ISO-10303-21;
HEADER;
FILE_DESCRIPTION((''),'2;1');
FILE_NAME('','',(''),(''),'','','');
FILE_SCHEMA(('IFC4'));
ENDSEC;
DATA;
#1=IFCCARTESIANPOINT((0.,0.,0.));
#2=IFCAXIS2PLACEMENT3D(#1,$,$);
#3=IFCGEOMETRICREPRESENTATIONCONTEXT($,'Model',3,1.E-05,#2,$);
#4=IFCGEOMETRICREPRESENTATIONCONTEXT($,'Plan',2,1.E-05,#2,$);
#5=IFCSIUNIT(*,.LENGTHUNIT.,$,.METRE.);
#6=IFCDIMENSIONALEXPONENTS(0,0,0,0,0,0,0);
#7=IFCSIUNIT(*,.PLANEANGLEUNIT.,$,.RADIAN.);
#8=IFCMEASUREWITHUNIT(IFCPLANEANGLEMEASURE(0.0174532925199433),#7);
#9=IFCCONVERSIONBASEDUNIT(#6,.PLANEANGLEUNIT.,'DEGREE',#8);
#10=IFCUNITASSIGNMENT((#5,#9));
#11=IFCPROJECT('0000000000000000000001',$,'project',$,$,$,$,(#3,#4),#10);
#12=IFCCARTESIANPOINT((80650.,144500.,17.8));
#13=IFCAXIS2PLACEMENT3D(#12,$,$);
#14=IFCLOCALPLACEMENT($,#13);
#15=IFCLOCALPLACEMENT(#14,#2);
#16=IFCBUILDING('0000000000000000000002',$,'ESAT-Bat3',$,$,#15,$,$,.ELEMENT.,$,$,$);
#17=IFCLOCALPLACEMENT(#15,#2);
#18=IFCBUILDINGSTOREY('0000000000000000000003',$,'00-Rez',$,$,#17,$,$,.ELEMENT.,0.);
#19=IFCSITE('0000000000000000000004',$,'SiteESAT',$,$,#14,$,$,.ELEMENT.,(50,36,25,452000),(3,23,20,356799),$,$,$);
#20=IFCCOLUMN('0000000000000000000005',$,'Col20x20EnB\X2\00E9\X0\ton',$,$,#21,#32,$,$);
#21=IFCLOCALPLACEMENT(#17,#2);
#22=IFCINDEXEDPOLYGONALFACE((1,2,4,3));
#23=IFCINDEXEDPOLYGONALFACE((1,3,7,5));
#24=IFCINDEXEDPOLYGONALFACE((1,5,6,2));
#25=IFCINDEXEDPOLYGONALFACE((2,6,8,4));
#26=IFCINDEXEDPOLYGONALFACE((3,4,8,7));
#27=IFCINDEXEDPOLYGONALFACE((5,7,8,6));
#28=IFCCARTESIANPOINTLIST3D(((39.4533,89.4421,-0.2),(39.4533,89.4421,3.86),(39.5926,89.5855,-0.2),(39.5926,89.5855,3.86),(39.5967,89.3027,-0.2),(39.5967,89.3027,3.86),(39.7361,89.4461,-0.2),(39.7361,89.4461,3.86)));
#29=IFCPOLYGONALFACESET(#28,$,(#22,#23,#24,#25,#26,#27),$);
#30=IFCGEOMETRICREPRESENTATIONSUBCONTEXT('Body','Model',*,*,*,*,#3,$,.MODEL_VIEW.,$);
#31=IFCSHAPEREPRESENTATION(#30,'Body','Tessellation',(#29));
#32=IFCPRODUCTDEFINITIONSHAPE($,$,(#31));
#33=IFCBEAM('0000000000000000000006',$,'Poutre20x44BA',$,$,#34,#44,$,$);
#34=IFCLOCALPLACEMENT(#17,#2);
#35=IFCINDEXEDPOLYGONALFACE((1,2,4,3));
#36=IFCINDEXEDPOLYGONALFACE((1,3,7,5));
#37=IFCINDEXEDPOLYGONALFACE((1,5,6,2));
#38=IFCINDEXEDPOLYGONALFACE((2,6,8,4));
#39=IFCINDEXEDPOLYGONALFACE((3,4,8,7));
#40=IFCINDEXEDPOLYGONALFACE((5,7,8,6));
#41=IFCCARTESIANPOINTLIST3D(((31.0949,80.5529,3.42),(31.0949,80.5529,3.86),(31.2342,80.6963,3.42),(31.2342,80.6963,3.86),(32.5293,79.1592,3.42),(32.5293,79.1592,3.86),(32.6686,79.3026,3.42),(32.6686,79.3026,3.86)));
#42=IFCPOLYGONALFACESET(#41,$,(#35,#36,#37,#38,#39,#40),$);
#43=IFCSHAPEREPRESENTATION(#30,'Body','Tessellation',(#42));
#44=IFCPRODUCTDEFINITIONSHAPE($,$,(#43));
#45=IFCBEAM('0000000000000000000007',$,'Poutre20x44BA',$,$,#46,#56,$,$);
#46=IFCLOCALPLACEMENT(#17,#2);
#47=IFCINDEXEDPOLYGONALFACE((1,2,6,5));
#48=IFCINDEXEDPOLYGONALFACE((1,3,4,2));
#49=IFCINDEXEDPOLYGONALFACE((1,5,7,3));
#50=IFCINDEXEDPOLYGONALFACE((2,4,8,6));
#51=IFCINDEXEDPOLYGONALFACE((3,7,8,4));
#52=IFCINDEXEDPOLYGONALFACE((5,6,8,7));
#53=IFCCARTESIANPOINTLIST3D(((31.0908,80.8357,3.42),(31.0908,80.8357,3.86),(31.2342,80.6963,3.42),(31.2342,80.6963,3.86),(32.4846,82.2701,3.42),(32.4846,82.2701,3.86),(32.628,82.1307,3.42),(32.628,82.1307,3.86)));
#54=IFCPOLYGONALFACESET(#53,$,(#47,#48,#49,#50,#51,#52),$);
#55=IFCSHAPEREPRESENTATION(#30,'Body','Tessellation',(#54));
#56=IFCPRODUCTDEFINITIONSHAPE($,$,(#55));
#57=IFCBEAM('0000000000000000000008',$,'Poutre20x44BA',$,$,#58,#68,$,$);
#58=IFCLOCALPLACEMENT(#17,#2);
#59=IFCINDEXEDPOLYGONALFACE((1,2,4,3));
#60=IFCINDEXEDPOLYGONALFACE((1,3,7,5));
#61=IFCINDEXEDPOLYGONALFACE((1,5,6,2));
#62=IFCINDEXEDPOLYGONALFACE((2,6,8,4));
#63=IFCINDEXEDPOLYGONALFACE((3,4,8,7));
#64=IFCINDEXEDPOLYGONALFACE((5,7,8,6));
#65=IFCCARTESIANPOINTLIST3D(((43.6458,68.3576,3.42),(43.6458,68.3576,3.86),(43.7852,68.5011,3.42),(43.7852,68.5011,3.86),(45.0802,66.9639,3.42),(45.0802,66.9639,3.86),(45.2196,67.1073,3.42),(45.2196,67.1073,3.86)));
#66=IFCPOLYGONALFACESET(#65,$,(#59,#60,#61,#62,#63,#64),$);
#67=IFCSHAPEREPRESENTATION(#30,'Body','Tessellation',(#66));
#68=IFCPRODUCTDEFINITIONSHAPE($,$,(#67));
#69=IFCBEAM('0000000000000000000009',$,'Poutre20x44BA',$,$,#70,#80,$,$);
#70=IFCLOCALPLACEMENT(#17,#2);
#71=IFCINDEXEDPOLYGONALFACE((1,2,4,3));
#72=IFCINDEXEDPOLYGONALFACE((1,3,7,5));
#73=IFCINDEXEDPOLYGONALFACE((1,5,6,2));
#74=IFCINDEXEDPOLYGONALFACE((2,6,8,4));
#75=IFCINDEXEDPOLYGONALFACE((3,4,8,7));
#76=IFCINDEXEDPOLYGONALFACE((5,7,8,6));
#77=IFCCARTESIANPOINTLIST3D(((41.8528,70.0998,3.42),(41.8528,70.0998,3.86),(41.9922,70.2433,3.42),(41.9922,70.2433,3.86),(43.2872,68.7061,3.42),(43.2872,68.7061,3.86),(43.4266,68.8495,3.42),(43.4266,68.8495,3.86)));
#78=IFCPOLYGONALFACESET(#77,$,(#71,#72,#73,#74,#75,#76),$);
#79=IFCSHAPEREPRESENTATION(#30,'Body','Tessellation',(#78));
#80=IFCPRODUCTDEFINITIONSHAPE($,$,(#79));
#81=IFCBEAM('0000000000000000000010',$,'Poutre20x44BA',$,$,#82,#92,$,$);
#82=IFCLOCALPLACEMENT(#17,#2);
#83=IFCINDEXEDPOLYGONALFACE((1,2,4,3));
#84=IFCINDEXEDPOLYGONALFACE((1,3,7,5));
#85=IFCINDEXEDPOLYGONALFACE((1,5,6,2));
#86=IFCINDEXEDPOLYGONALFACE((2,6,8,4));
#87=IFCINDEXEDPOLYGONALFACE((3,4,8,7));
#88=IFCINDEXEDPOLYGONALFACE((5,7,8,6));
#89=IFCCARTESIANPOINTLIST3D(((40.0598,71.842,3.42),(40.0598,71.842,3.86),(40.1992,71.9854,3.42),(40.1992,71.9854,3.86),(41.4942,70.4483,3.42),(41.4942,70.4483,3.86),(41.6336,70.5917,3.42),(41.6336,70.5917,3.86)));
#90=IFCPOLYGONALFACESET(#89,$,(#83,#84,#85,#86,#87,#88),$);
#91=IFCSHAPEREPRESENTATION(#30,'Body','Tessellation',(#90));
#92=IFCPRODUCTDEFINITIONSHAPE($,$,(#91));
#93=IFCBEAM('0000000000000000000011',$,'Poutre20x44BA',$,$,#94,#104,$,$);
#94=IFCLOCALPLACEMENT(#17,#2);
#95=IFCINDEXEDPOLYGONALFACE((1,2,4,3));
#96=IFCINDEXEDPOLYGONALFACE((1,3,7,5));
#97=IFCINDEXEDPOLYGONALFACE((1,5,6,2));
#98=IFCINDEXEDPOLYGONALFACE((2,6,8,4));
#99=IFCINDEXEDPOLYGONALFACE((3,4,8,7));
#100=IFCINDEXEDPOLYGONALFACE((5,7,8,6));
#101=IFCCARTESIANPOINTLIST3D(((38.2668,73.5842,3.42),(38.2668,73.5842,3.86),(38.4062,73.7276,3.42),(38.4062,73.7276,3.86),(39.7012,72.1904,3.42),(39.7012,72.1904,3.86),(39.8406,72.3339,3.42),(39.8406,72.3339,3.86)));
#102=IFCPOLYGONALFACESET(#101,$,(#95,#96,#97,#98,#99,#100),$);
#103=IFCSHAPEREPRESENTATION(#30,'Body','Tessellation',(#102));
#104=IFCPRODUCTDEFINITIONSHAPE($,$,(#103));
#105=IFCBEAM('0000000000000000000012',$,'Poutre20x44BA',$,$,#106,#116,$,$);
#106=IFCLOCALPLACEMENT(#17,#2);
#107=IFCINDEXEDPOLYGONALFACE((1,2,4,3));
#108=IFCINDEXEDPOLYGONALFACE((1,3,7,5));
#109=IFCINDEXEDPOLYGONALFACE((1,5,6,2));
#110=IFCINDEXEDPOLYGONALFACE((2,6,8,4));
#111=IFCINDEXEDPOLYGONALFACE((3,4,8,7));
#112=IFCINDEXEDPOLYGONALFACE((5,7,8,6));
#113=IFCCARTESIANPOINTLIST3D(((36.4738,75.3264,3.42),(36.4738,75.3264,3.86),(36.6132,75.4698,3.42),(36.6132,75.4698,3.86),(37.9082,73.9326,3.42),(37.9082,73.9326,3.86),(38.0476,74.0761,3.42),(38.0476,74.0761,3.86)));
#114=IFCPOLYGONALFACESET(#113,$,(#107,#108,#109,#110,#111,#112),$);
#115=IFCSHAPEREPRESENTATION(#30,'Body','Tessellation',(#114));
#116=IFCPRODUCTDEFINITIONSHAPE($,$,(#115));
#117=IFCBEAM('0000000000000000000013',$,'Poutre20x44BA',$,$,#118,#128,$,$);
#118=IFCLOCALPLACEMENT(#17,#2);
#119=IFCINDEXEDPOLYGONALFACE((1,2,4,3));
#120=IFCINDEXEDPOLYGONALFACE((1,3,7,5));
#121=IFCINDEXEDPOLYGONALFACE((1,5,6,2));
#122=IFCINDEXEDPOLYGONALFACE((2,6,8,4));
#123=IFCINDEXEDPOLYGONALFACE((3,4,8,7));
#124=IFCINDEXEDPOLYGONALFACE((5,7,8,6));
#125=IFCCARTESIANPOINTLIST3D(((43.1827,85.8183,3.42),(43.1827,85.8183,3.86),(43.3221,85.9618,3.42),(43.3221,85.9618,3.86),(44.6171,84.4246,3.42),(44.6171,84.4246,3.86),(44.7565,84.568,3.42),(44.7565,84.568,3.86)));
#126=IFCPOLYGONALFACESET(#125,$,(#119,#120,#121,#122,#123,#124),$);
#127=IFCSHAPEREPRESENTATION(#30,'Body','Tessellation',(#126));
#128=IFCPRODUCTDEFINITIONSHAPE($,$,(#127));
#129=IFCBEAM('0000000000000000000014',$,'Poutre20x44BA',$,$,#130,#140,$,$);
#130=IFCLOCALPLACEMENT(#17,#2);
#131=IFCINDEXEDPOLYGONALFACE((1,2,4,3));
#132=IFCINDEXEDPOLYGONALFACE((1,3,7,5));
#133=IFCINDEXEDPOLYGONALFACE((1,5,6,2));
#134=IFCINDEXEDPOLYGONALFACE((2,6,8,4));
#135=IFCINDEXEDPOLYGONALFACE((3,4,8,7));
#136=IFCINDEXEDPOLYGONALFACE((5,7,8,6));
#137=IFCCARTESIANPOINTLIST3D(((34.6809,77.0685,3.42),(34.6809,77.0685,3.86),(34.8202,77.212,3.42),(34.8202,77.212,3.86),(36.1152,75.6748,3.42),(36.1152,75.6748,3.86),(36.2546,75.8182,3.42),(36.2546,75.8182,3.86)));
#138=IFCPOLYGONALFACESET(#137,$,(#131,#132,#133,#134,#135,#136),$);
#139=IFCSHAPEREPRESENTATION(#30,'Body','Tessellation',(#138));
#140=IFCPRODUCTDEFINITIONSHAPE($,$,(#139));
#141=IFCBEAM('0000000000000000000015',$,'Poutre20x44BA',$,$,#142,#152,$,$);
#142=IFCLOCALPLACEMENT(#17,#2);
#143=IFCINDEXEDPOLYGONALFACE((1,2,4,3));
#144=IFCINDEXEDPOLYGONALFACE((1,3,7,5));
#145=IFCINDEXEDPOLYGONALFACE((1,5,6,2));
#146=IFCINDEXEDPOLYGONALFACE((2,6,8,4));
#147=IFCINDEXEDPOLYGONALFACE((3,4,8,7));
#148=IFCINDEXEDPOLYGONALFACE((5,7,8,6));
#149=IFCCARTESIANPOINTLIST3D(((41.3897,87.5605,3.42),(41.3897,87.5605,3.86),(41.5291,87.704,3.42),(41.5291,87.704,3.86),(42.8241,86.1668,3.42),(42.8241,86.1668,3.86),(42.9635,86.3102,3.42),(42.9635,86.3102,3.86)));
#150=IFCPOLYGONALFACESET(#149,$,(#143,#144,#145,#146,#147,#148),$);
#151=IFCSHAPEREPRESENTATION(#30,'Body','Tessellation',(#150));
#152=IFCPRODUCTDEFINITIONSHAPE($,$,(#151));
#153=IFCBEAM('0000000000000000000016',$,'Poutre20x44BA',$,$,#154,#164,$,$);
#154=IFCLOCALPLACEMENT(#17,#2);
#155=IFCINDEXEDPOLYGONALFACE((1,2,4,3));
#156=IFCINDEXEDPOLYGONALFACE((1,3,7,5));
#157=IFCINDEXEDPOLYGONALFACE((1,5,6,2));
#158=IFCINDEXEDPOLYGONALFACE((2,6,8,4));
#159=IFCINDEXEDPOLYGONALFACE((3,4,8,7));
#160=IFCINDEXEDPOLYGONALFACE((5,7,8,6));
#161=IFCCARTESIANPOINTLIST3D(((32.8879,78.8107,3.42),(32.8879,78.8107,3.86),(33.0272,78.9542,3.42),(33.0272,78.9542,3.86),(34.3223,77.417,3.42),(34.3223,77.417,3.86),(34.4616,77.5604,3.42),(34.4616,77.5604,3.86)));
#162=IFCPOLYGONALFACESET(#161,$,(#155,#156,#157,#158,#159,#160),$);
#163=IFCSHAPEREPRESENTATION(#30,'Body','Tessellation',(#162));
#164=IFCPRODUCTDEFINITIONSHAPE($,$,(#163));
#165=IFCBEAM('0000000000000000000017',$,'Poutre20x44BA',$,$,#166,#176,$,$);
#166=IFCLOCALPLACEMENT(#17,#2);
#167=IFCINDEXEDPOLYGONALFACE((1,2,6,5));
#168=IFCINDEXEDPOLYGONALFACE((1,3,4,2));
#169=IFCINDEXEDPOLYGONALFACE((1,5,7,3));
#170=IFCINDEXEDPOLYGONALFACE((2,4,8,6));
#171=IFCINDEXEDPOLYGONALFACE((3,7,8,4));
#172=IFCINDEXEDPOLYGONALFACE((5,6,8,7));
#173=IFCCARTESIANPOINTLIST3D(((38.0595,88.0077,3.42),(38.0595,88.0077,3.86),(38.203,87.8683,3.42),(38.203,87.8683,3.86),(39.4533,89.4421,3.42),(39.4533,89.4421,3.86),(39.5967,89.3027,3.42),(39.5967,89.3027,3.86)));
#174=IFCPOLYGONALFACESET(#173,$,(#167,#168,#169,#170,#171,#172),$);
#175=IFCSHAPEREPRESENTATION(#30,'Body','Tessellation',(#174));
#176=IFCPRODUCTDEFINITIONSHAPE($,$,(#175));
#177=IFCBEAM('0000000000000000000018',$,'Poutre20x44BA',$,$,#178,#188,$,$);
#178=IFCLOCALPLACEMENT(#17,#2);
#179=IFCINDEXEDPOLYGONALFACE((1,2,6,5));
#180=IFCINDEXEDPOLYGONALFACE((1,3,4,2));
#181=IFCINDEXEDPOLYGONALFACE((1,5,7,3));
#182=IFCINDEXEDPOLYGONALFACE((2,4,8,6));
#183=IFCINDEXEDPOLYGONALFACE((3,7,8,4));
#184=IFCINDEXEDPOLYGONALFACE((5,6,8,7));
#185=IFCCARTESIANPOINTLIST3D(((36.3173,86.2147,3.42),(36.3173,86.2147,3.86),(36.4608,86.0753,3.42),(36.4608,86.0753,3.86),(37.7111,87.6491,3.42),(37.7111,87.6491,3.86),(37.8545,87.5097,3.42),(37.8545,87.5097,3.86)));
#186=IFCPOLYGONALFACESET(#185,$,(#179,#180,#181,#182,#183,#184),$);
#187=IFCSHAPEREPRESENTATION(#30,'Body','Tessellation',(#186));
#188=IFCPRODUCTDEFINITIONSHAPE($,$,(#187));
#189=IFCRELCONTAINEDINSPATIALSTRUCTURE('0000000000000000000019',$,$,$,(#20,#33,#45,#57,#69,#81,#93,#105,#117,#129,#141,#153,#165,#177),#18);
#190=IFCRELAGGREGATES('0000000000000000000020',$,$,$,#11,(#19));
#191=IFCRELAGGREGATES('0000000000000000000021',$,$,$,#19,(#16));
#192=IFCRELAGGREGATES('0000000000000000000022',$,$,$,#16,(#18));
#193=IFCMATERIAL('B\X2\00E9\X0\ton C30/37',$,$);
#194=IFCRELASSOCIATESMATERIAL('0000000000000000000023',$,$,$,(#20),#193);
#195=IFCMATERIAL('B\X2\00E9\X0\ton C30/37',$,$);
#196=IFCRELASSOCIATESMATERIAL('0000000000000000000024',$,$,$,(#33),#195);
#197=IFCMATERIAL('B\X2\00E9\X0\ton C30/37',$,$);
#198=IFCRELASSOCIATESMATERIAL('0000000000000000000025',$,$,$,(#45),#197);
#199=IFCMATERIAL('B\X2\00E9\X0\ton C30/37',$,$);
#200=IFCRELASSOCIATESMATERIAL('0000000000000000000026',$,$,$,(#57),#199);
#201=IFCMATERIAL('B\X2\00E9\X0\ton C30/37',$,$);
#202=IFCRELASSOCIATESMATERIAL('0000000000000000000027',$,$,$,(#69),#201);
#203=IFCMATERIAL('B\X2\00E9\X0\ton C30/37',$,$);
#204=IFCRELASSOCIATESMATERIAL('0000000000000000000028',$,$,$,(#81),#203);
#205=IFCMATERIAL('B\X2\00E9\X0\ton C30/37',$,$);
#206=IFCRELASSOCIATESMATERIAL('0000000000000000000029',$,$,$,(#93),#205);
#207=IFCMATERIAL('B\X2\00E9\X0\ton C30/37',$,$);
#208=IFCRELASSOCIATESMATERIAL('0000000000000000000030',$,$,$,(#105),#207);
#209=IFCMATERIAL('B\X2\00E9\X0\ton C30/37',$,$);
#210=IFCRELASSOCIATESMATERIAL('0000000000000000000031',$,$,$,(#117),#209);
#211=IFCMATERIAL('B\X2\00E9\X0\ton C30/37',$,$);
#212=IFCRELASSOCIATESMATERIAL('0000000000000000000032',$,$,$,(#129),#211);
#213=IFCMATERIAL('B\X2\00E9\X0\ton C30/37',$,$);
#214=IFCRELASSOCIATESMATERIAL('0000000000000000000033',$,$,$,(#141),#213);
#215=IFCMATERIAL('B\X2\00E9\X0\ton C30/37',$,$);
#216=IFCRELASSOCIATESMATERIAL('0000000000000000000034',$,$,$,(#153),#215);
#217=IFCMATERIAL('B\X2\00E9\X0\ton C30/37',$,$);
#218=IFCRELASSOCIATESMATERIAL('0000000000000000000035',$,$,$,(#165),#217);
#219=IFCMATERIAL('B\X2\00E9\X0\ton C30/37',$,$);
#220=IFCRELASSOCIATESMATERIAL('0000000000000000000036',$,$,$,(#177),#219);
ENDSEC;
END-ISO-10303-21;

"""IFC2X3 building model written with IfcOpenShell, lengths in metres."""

from ifc_helpers import new_model, entity, si_unit, converted_unit, frame, frame_2d, origin, origin_with_axes, place, context, subcontext, project, spatial, rectangle, extrude, material, element, save


model = new_model("IFC2X3")

# Units and contexts
model_context = context("Model", 3, precision=1e-05, world=origin())
plan_context = context("Plan", 2, precision=1e-05, world=origin())
body_context = subcontext(model_context, "Body", "Model", "MODEL_VIEW")
ifc_project = project(units=[si_unit("LENGTHUNIT", "METRE"), converted_unit("PLANEANGLEUNIT", "DEGREE", entity("IfcPlaneAngleMeasure", 0.0174532925199433), si_unit("PLANEANGLEUNIT", "RADIAN"), dimensions=[0, 0, 0, 0, 0, 0, 0])], contexts=[model_context, plan_context])

# Site, building, storey
site_placement = place(None, frame((80650.0, 144500.0, 17.8)))
site = spatial("IfcSite", under=ifc_project, at=site_placement, Name="SiteESAT", CompositionType="ELEMENT", RefLatitude=(50, 36, 25, 452000), RefLongitude=(3, 23, 20, 356799))
building_placement = place(site_placement, origin())
building = spatial("IfcBuilding", under=site, at=building_placement, Name="ESAT-Bat3", CompositionType="ELEMENT")
storey_placement = place(building_placement, origin())
storey = spatial("IfcBuildingStorey", under=building, at=storey_placement, Name="00-Rez", CompositionType="ELEMENT", Elevation=0.0)

# Column
ifc_material_1 = material(Name="Béton C30/37")
column_1_placement = place(storey_placement, frame((39.5967, 89.3027, -0.2)))
element("IfcColumn", 1, at=column_1_placement, inside=storey, material=ifc_material_1, Name="Col20x20EnBéton", context=body_context, shape_type="SweptSolid", body=[
    extrude(rectangle(XDim=0.2, YDim=0.2, at=frame_2d((-0.002, 0.1414), x_axis=(0.696872, 0.717196))), origin_with_axes(), (0.0, 0.0, 1.0), 4.06),
])

# Beams
ifc_material_2 = material(Name="Béton C30/37")
beam_1_placement = place(storey_placement, frame((32.6686, 79.3026, 3.42), z_axis=(0.0, 0.0, 1.0), x_axis=(-0.717196, 0.696872, 0.0)))
element("IfcBeam", 2, at=beam_1_placement, inside=storey, material=ifc_material_2, Name="Poutre20x44BA", context=body_context, shape_type="SweptSolid", body=[
    extrude(rectangle(XDim=0.2, YDim=0.44, at=frame_2d((0.1, 0.22), x_axis=(1.0, 0.0))), frame((0.0, 0.0, 0.0), z_axis=(1.0, 0.0, 0.0), x_axis=(0.0, 1.0, 0.0)), (0.0, 0.0, 1.0), 2.0),
])
ifc_material_3 = material(Name="Béton C30/37")
beam_2_placement = place(storey_placement, frame((31.2342, 80.6963, 3.42), z_axis=(0.0, 0.0, 1.0), x_axis=(0.696872, 0.717196, 0.0)))
element("IfcBeam", 3, at=beam_2_placement, inside=storey, material=ifc_material_3, Name="Poutre20x44BA", context=body_context, shape_type="SweptSolid", body=[
    extrude(rectangle(XDim=0.2, YDim=0.44, at=frame_2d((0.1, 0.22), x_axis=(1.0, 0.0))), frame((0.0, 0.0, 0.0), z_axis=(1.0, 0.0, 0.0), x_axis=(0.0, 1.0, 0.0)), (0.0, 0.0, 1.0), 2.0),
])
ifc_material_4 = material(Name="Béton C30/37")
beam_3_placement = place(storey_placement, frame((45.2196, 67.1073, 3.42), z_axis=(0.0, 0.0, 1.0), x_axis=(-0.717196, 0.696872, 0.0)))
element("IfcBeam", 4, at=beam_3_placement, inside=storey, material=ifc_material_4, Name="Poutre20x44BA", context=body_context, shape_type="SweptSolid", body=[
    extrude(rectangle(XDim=0.2, YDim=0.44, at=frame_2d((0.1, 0.22), x_axis=(1.0, 0.0))), frame((0.0, 0.0, 0.0), z_axis=(1.0, 0.0, 0.0), x_axis=(0.0, 1.0, 0.0)), (0.0, 0.0, 1.0), 2.0),
])
ifc_material_5 = material(Name="Béton C30/37")
beam_4_placement = place(storey_placement, frame((43.4266, 68.8495, 3.42), z_axis=(0.0, 0.0, 1.0), x_axis=(-0.717196, 0.696872, 0.0)))
element("IfcBeam", 5, at=beam_4_placement, inside=storey, material=ifc_material_5, Name="Poutre20x44BA", context=body_context, shape_type="SweptSolid", body=[
    extrude(rectangle(XDim=0.2, YDim=0.44, at=frame_2d((0.1, 0.22), x_axis=(1.0, 0.0))), frame((0.0, 0.0, 0.0), z_axis=(1.0, 0.0, 0.0), x_axis=(0.0, 1.0, 0.0)), (0.0, 0.0, 1.0), 2.0),
])
ifc_material_6 = material(Name="Béton C30/37")
beam_5_placement = place(storey_placement, frame((41.6336, 70.5917, 3.42), z_axis=(0.0, 0.0, 1.0), x_axis=(-0.717196, 0.696872, 0.0)))
element("IfcBeam", 6, at=beam_5_placement, inside=storey, material=ifc_material_6, Name="Poutre20x44BA", context=body_context, shape_type="SweptSolid", body=[
    extrude(rectangle(XDim=0.2, YDim=0.44, at=frame_2d((0.1, 0.22), x_axis=(1.0, 0.0))), frame((0.0, 0.0, 0.0), z_axis=(1.0, 0.0, 0.0), x_axis=(0.0, 1.0, 0.0)), (0.0, 0.0, 1.0), 2.0),
])
ifc_material_7 = material(Name="Béton C30/37")
beam_6_placement = place(storey_placement, frame((39.8406, 72.3339, 3.42), z_axis=(0.0, 0.0, 1.0), x_axis=(-0.717196, 0.696872, 0.0)))
element("IfcBeam", 7, at=beam_6_placement, inside=storey, material=ifc_material_7, Name="Poutre20x44BA", context=body_context, shape_type="SweptSolid", body=[
    extrude(rectangle(XDim=0.2, YDim=0.44, at=frame_2d((0.1, 0.22), x_axis=(1.0, 0.0))), frame((0.0, 0.0, 0.0), z_axis=(1.0, 0.0, 0.0), x_axis=(0.0, 1.0, 0.0)), (0.0, 0.0, 1.0), 2.0),
])
ifc_material_8 = material(Name="Béton C30/37")
beam_7_placement = place(storey_placement, frame((38.0476, 74.0761, 3.42), z_axis=(0.0, 0.0, 1.0), x_axis=(-0.717196, 0.696872, 0.0)))
element("IfcBeam", 8, at=beam_7_placement, inside=storey, material=ifc_material_8, Name="Poutre20x44BA", context=body_context, shape_type="SweptSolid", body=[
    extrude(rectangle(XDim=0.2, YDim=0.44, at=frame_2d((0.1, 0.22), x_axis=(1.0, 0.0))), frame((0.0, 0.0, 0.0), z_axis=(1.0, 0.0, 0.0), x_axis=(0.0, 1.0, 0.0)), (0.0, 0.0, 1.0), 2.0),
])
ifc_material_9 = material(Name="Béton C30/37")
beam_8_placement = place(storey_placement, frame((44.7565, 84.568, 3.42), z_axis=(0.0, 0.0, 1.0), x_axis=(-0.717196, 0.696872, 0.0)))
element("IfcBeam", 9, at=beam_8_placement, inside=storey, material=ifc_material_9, Name="Poutre20x44BA", context=body_context, shape_type="SweptSolid", body=[
    extrude(rectangle(XDim=0.2, YDim=0.44, at=frame_2d((0.1, 0.22), x_axis=(1.0, 0.0))), frame((0.0, 0.0, 0.0), z_axis=(1.0, 0.0, 0.0), x_axis=(0.0, 1.0, 0.0)), (0.0, 0.0, 1.0), 2.0),
])
ifc_material_10 = material(Name="Béton C30/37")
beam_9_placement = place(storey_placement, frame((36.2546, 75.8182, 3.42), z_axis=(0.0, 0.0, 1.0), x_axis=(-0.717196, 0.696872, 0.0)))
element("IfcBeam", 10, at=beam_9_placement, inside=storey, material=ifc_material_10, Name="Poutre20x44BA", context=body_context, shape_type="SweptSolid", body=[
    extrude(rectangle(XDim=0.2, YDim=0.44, at=frame_2d((0.1, 0.22), x_axis=(1.0, 0.0))), frame((0.0, 0.0, 0.0), z_axis=(1.0, 0.0, 0.0), x_axis=(0.0, 1.0, 0.0)), (0.0, 0.0, 1.0), 2.0),
])
ifc_material_11 = material(Name="Béton C30/37")
beam_10_placement = place(storey_placement, frame((42.9635, 86.3102, 3.42), z_axis=(0.0, 0.0, 1.0), x_axis=(-0.717196, 0.696872, 0.0)))
element("IfcBeam", 11, at=beam_10_placement, inside=storey, material=ifc_material_11, Name="Poutre20x44BA", context=body_context, shape_type="SweptSolid", body=[
    extrude(rectangle(XDim=0.2, YDim=0.44, at=frame_2d((0.1, 0.22), x_axis=(1.0, 0.0))), frame((0.0, 0.0, 0.0), z_axis=(1.0, 0.0, 0.0), x_axis=(0.0, 1.0, 0.0)), (0.0, 0.0, 1.0), 2.0),
])
ifc_material_12 = material(Name="Béton C30/37")
beam_11_placement = place(storey_placement, frame((34.4616, 77.5604, 3.42), z_axis=(0.0, 0.0, 1.0), x_axis=(-0.717196, 0.696872, 0.0)))
element("IfcBeam", 12, at=beam_11_placement, inside=storey, material=ifc_material_12, Name="Poutre20x44BA", context=body_context, shape_type="SweptSolid", body=[
    extrude(rectangle(XDim=0.2, YDim=0.44, at=frame_2d((0.1, 0.22), x_axis=(1.0, 0.0))), frame((0.0, 0.0, 0.0), z_axis=(1.0, 0.0, 0.0), x_axis=(0.0, 1.0, 0.0)), (0.0, 0.0, 1.0), 2.0),
])
ifc_material_13 = material(Name="Béton C30/37")
beam_12_placement = place(storey_placement, frame((38.203, 87.8683, 3.42), z_axis=(0.0, 0.0, 1.0), x_axis=(0.696872, 0.717196, 0.0)))
element("IfcBeam", 13, at=beam_12_placement, inside=storey, material=ifc_material_13, Name="Poutre20x44BA", context=body_context, shape_type="SweptSolid", body=[
    extrude(rectangle(XDim=0.2, YDim=0.44, at=frame_2d((0.1, 0.22), x_axis=(1.0, 0.0))), frame((0.0, 0.0, 0.0), z_axis=(1.0, 0.0, 0.0), x_axis=(0.0, 1.0, 0.0)), (0.0, 0.0, 1.0), 2.0),
])
ifc_material_14 = material(Name="Béton C30/37")
beam_13_placement = place(storey_placement, frame((36.4608, 86.0753, 3.42), z_axis=(0.0, 0.0, 1.0), x_axis=(0.696872, 0.717196, 0.0)))
element("IfcBeam", 14, at=beam_13_placement, inside=storey, material=ifc_material_14, Name="Poutre20x44BA", context=body_context, shape_type="SweptSolid", body=[
    extrude(rectangle(XDim=0.2, YDim=0.44, at=frame_2d((0.1, 0.22), x_axis=(1.0, 0.0))), frame((0.0, 0.0, 0.0), z_axis=(1.0, 0.0, 0.0), x_axis=(0.0, 1.0, 0.0)), (0.0, 0.0, 1.0), 2.0),
])

save(model, "model.ifc")
